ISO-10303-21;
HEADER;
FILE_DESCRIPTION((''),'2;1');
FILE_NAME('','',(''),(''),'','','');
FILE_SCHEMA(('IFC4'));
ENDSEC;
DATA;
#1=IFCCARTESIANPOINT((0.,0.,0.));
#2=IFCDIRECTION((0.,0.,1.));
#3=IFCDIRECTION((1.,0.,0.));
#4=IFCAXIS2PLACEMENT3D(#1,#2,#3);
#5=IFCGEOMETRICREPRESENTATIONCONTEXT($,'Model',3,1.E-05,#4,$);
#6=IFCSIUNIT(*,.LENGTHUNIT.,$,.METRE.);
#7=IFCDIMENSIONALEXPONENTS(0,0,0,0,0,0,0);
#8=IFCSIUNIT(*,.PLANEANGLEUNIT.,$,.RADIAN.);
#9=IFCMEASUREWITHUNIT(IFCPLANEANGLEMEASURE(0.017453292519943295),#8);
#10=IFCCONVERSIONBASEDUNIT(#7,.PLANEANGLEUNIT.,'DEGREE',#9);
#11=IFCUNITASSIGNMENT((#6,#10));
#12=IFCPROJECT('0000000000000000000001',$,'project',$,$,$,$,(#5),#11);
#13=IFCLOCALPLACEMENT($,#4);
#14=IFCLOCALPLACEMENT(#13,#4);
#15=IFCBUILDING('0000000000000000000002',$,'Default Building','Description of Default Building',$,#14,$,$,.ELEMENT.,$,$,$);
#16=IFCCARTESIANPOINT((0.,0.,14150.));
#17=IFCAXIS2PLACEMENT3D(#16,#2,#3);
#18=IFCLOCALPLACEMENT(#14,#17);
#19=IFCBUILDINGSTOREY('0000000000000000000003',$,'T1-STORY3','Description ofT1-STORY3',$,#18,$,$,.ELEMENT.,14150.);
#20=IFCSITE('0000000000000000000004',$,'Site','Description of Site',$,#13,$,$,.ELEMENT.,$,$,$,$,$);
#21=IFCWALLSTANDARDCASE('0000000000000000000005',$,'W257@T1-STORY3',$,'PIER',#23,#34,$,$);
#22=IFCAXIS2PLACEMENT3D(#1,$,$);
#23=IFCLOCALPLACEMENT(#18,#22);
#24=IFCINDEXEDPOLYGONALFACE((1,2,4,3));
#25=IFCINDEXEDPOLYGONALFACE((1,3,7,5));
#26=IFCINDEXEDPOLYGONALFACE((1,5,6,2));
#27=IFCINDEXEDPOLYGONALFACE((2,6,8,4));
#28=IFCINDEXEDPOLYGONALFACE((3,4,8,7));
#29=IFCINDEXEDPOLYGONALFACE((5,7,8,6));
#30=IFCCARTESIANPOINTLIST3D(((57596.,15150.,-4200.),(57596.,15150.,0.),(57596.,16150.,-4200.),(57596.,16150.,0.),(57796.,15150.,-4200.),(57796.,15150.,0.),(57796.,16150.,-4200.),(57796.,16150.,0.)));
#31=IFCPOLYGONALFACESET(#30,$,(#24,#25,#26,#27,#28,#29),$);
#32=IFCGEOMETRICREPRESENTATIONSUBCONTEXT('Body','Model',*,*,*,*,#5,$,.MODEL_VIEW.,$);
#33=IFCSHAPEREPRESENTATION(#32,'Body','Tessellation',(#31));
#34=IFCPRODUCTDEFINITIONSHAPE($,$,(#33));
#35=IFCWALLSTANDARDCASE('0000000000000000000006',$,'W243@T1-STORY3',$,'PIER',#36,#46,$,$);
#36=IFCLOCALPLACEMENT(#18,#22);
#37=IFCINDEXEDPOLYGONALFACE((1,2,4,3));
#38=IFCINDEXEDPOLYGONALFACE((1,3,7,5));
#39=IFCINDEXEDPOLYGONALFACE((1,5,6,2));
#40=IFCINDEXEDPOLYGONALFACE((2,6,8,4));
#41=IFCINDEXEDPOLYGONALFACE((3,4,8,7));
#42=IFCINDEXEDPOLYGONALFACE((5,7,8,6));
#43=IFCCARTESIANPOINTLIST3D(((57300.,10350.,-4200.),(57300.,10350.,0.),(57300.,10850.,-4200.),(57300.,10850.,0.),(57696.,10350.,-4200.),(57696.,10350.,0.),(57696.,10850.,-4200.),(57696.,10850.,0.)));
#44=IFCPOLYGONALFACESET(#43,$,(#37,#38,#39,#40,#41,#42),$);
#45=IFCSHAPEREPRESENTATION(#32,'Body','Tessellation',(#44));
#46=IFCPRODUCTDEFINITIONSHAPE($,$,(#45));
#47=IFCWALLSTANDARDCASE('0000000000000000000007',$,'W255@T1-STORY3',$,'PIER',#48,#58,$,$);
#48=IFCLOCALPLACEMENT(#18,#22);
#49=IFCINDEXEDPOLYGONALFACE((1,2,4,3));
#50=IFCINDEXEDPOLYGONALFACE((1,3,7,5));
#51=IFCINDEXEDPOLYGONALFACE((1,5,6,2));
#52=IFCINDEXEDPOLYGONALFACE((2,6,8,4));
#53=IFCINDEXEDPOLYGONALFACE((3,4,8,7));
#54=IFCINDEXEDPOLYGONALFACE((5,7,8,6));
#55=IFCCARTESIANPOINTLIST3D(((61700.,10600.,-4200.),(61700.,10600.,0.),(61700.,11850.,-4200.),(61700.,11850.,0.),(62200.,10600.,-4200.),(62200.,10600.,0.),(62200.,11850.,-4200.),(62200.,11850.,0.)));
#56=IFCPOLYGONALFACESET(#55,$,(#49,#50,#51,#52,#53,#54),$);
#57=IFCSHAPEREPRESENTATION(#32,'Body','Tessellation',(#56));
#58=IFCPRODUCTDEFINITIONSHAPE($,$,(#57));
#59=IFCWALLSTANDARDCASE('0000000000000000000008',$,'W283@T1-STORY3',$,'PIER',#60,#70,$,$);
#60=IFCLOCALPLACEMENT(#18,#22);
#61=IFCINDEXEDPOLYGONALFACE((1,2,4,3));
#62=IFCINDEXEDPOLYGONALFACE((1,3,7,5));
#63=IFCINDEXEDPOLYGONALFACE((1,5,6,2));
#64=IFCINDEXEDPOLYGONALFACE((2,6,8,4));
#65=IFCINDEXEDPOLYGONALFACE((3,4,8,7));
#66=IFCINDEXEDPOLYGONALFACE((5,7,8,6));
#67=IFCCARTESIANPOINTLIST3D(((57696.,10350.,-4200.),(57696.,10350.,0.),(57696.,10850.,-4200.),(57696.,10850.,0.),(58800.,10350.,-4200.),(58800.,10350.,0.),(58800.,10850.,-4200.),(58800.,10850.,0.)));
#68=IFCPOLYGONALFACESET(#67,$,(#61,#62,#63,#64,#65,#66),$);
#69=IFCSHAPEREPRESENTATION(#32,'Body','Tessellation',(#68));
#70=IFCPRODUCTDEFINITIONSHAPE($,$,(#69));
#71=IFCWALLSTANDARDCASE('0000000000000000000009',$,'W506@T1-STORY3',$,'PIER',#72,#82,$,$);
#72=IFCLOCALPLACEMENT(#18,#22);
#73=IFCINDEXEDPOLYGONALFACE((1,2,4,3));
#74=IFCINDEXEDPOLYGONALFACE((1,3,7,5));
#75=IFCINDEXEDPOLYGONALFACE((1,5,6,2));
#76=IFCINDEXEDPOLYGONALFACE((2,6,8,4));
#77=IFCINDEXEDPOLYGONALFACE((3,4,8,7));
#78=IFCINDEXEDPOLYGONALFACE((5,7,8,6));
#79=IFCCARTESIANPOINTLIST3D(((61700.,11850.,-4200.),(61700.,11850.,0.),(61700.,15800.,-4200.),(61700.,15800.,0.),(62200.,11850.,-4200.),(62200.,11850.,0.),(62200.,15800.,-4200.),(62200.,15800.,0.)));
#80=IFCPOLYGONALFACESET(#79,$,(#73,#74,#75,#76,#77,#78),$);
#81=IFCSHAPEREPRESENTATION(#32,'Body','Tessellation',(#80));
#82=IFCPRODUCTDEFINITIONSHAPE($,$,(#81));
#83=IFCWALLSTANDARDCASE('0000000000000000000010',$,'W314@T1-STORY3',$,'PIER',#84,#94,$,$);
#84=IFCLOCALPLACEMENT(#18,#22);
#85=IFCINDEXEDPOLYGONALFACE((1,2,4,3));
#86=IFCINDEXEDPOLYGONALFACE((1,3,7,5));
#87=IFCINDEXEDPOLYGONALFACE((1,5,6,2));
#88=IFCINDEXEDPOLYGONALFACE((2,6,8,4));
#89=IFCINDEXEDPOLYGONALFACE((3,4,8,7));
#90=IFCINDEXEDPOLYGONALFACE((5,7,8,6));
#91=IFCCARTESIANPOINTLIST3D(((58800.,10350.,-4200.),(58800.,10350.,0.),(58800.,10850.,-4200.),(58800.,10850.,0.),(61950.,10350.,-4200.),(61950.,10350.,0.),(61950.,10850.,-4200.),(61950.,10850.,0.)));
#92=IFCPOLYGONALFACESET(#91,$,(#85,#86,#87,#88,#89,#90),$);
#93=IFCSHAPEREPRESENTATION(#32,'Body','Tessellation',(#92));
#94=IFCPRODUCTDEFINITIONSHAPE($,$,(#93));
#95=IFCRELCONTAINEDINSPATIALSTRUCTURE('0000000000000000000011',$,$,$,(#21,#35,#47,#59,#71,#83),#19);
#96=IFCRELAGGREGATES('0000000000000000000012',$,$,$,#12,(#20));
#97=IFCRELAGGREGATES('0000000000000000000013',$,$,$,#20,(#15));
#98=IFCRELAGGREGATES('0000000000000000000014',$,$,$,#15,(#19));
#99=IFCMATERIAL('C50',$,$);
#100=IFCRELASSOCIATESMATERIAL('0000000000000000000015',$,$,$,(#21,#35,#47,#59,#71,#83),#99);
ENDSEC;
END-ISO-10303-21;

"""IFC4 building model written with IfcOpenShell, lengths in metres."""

from ifc_helpers import new_model, entity, si_unit, converted_unit, frame, origin_with_axes, place, context, subcontext, project, spatial, indexed_curve, outline, extrude, material, element, save


model = new_model("IFC4")

# Units and contexts
model_context = context("Model", 3, precision=1e-05, world=origin_with_axes())
body_context = subcontext(model_context, "Body", "Model", "MODEL_VIEW")
ifc_project = project(units=[si_unit("LENGTHUNIT", "METRE"), converted_unit("PLANEANGLEUNIT", "DEGREE", entity("IfcPlaneAngleMeasure", 0.017453292519943295), si_unit("PLANEANGLEUNIT", "RADIAN"), dimensions=[0, 0, 0, 0, 0, 0, 0])], contexts=[model_context])

# Site, building, storey
site_placement = place(None, origin_with_axes())
site = spatial("IfcSite", under=ifc_project, at=site_placement, Name="Site", Description="Description of Site", CompositionType="ELEMENT")
building_placement = place(site_placement, origin_with_axes())
building = spatial("IfcBuilding", under=site, at=building_placement, Name="Default Building", Description="Description of Default Building", CompositionType="ELEMENT")
storey_placement = place(building_placement, frame((0.0, 0.0, 14150.0), z_axis=(0.0, 0.0, 1.0), x_axis=(1.0, 0.0, 0.0)))
storey = spatial("IfcBuildingStorey", under=building, at=storey_placement, Name="T1-STORY3", Description="Description ofT1-STORY3", CompositionType="ELEMENT", Elevation=14150.0)

# Shared definitions
ifc_material_1 = material(Name="C50")

# Walls
wall_1_placement = place(storey_placement, frame((57696.0, 15150.0, -4200.0), z_axis=(0.0, 0.0, 1.0), x_axis=(0.0, 1.0, 0.0)))
element("IfcWallStandardCase", 1, at=wall_1_placement, inside=storey, material=ifc_material_1, Name="W257@T1-STORY3", ObjectType="PIER", context=body_context, shape_type="SweptSolid", body=[
    extrude(outline(indexed_curve([(0.0, -100.0), (0.0, 100.0), (1000.0, 100.0), (1000.0, -100.0), (0.0, -100.0)], self_intersect=False)), origin_with_axes(), (0.0, 0.0, 1.0), 4200.0),
])
wall_2_placement = place(storey_placement, frame((57300.0, 10600.0, -4200.0), z_axis=(0.0, 0.0, 1.0), x_axis=(1.0, 0.0, 0.0)))
element("IfcWallStandardCase", 2, at=wall_2_placement, inside=storey, material=ifc_material_1, Name="W243@T1-STORY3", ObjectType="PIER", context=body_context, shape_type="SweptSolid", body=[
    extrude(outline(indexed_curve([(0.0, -250.0), (0.0, 250.0), (396.0, 250.0), (396.0, -250.0), (0.0, -250.0)], self_intersect=False)), origin_with_axes(), (0.0, 0.0, 1.0), 4200.0),
])
wall_3_placement = place(storey_placement, frame((61950.0, 10600.0, -4200.0), z_axis=(0.0, 0.0, 1.0), x_axis=(0.0, 1.0, 0.0)))
element("IfcWallStandardCase", 3, at=wall_3_placement, inside=storey, material=ifc_material_1, Name="W255@T1-STORY3", ObjectType="PIER", context=body_context, shape_type="SweptSolid", body=[
    extrude(outline(indexed_curve([(0.0, -250.0), (0.0, 250.0), (1250.0, 250.0), (1250.0, -250.0), (0.0, -250.0)], self_intersect=False)), origin_with_axes(), (0.0, 0.0, 1.0), 4200.0),
])
wall_4_placement = place(storey_placement, frame((57696.0, 10600.0, -4200.0), z_axis=(0.0, 0.0, 1.0), x_axis=(1.0, 0.0, 0.0)))
element("IfcWallStandardCase", 4, at=wall_4_placement, inside=storey, material=ifc_material_1, Name="W283@T1-STORY3", ObjectType="PIER", context=body_context, shape_type="SweptSolid", body=[
    extrude(outline(indexed_curve([(0.0, -250.0), (0.0, 250.0), (1104.0, 250.0), (1104.0, -250.0), (0.0, -250.0)], self_intersect=False)), origin_with_axes(), (0.0, 0.0, 1.0), 4200.0),
])
wall_5_placement = place(storey_placement, frame((61950.0, 11850.0, -4200.0), z_axis=(0.0, 0.0, 1.0), x_axis=(0.0, 1.0, 0.0)))
element("IfcWallStandardCase", 5, at=wall_5_placement, inside=storey, material=ifc_material_1, Name="W506@T1-STORY3", ObjectType="PIER", context=body_context, shape_type="SweptSolid", body=[
    extrude(outline(indexed_curve([(0.0, -250.0), (0.0, 250.0), (3950.0, 250.0), (3950.0, -250.0), (0.0, -250.0)], self_intersect=False)), origin_with_axes(), (0.0, 0.0, 1.0), 4200.0),
])
wall_6_placement = place(storey_placement, frame((58800.0, 10600.0, -4200.0), z_axis=(0.0, 0.0, 1.0), x_axis=(1.0, 0.0, 0.0)))
element("IfcWallStandardCase", 6, at=wall_6_placement, inside=storey, material=ifc_material_1, Name="W314@T1-STORY3", ObjectType="PIER", context=body_context, shape_type="SweptSolid", body=[
    extrude(outline(indexed_curve([(0.0, -250.0), (0.0, 250.0), (3150.0, 250.0), (3150.0, -250.0), (0.0, -250.0)], self_intersect=False)), origin_with_axes(), (0.0, 0.0, 1.0), 4200.0),
])

save(model, "model.ifc")
